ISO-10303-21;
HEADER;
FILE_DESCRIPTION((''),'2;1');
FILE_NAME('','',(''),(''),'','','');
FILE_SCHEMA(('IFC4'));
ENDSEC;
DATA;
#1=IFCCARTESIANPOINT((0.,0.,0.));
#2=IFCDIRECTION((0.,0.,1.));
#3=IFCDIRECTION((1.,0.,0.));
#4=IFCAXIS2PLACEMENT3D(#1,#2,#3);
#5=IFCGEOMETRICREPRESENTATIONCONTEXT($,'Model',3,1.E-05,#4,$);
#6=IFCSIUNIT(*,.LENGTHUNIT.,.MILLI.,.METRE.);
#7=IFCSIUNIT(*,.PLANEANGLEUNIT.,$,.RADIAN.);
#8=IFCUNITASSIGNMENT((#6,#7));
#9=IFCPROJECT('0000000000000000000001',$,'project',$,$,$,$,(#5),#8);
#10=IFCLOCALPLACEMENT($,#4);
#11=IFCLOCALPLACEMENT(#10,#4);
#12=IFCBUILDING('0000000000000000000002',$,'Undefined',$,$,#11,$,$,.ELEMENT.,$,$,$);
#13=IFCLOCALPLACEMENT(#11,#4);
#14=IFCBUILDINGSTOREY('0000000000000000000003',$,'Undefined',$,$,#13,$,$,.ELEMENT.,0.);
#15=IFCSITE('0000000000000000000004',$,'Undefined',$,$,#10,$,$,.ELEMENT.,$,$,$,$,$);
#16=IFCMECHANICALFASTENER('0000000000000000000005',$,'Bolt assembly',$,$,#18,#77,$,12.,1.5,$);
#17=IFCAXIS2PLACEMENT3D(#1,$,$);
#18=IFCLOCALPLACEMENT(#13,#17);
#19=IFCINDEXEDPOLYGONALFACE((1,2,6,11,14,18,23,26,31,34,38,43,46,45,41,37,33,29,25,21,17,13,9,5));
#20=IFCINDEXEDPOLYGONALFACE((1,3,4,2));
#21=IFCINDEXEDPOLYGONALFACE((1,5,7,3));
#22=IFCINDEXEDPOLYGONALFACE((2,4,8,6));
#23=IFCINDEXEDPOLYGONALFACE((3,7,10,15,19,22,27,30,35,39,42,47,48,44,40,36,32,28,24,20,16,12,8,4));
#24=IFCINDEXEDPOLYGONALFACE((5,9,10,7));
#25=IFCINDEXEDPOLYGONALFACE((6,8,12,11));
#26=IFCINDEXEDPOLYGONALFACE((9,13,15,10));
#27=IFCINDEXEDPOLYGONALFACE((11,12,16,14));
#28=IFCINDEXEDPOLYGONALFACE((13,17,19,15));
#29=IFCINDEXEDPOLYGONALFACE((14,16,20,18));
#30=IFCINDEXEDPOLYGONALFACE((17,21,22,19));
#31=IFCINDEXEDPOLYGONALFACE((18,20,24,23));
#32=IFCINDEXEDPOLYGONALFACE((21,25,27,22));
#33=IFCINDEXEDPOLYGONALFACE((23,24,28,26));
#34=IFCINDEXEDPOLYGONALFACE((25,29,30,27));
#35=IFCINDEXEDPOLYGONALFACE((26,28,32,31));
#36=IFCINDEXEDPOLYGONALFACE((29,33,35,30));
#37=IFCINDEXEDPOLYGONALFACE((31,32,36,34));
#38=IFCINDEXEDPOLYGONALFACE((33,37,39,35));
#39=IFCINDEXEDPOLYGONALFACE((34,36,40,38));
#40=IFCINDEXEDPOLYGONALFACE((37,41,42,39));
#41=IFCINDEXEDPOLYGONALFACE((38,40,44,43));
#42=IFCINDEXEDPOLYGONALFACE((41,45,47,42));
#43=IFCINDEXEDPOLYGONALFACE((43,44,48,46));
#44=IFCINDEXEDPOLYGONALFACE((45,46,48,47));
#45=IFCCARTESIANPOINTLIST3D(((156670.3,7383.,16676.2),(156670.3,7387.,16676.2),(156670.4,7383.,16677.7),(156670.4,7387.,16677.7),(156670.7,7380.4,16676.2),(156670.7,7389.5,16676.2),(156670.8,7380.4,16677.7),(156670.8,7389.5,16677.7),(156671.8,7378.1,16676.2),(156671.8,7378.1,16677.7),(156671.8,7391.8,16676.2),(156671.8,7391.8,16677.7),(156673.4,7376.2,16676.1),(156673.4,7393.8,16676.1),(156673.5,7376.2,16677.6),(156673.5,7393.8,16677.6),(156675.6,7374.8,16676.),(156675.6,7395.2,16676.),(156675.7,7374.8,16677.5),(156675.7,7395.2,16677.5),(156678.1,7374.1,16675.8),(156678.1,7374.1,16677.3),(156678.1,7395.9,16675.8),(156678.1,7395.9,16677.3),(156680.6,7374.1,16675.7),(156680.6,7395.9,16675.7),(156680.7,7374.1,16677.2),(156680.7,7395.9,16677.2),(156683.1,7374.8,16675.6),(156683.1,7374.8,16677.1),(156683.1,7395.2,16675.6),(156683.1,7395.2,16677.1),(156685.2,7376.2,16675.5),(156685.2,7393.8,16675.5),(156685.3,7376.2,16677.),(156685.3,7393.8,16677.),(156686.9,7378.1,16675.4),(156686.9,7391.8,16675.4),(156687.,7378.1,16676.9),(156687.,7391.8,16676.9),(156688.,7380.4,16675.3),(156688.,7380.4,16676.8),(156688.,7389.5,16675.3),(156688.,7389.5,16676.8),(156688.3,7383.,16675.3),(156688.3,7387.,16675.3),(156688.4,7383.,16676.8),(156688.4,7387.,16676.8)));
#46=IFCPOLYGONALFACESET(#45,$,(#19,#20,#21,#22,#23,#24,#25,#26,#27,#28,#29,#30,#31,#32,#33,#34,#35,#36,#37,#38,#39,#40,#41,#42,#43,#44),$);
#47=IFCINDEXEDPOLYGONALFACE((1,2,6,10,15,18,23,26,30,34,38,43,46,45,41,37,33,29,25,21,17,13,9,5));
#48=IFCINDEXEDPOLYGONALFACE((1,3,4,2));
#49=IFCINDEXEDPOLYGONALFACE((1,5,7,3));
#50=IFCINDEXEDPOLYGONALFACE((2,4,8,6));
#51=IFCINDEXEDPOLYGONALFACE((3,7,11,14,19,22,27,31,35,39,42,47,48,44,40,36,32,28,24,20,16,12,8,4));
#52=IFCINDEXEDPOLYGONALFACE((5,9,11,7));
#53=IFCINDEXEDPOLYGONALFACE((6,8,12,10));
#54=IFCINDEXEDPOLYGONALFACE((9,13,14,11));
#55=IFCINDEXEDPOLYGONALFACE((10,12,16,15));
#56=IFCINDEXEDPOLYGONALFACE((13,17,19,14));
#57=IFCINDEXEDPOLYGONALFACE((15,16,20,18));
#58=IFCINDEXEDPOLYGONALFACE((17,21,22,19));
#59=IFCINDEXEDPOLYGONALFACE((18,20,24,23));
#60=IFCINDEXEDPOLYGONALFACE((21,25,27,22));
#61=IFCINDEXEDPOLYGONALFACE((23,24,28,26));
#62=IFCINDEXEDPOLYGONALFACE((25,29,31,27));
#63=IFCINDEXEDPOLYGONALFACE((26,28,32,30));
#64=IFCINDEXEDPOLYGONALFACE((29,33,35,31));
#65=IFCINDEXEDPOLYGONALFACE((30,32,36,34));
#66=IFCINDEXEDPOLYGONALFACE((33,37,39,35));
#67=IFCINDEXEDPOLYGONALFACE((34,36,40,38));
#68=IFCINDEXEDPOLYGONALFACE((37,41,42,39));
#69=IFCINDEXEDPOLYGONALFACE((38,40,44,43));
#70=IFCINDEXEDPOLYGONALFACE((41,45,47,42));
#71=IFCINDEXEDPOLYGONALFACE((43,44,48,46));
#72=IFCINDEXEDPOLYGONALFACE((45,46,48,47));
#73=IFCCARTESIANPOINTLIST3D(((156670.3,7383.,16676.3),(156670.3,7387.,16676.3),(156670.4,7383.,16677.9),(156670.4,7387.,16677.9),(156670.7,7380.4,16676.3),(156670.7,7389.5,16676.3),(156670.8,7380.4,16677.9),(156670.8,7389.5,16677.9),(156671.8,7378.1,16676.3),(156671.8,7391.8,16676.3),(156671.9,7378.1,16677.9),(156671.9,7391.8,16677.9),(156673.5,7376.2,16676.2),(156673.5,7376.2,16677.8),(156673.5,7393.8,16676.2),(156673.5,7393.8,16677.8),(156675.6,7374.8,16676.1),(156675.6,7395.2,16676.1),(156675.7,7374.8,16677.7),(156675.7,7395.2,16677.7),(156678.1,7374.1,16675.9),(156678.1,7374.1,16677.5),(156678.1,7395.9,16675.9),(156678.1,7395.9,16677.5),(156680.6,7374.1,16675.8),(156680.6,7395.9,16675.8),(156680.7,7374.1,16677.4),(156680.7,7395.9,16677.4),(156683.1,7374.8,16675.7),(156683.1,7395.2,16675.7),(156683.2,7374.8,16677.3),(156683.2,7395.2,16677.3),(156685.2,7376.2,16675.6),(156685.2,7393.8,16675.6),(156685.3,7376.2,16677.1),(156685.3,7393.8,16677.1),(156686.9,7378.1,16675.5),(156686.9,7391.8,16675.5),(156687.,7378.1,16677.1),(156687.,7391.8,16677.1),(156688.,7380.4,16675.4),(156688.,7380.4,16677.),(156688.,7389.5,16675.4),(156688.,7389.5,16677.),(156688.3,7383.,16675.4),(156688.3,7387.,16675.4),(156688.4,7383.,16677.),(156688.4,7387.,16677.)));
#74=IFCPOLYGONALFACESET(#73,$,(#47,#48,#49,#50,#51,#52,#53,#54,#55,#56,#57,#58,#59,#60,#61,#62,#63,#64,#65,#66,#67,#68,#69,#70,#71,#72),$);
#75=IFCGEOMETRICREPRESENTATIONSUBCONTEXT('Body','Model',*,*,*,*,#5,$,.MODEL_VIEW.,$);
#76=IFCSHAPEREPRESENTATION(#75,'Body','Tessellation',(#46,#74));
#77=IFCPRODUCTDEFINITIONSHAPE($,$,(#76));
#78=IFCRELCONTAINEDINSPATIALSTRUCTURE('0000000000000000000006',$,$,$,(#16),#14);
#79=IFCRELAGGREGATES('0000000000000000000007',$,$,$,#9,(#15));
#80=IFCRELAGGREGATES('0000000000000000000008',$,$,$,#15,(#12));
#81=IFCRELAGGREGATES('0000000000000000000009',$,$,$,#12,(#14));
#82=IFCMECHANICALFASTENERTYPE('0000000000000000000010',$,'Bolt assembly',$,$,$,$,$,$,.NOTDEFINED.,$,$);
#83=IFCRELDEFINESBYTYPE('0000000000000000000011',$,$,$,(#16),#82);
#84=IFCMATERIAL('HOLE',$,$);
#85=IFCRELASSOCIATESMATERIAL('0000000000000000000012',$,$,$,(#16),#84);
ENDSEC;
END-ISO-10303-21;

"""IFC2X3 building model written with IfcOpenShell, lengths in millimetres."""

from ifc_helpers import new_model, entity, si_unit, frame, origin_with_axes, place, context, subcontext, project, spatial, source, transform, mapped, material, type_object, element, save


model = new_model("IFC2X3")

# Units and contexts
model_context = context("Model", 3, precision=1e-05, world=origin_with_axes())
body_context = subcontext(model_context, "Body", "Model", "MODEL_VIEW")
ifc_project = project(units=[si_unit("LENGTHUNIT", "METRE", prefix="MILLI"), si_unit("PLANEANGLEUNIT", "RADIAN")], contexts=[model_context])

# Site, building, storey
site_placement = place(None, origin_with_axes())
site = spatial("IfcSite", under=ifc_project, at=site_placement, Name="Undefined", CompositionType="ELEMENT")
building_placement = place(site_placement, origin_with_axes())
building = spatial("IfcBuilding", under=site, at=building_placement, Name="Undefined", CompositionType="ELEMENT")
storey_placement = place(building_placement, origin_with_axes())
storey = spatial("IfcBuildingStorey", under=building, at=storey_placement, Name="Undefined", CompositionType="ELEMENT", Elevation=0.0)

# Mechanical fastener
ifc_material_1 = material(Name="HOLE")
mechanical_fastener_type = type_object("IfcMechanicalFastenerType", Name="Bolt assembly")
shared_circle_1 = entity("IfcCircle", entity("IfcAxis2Placement2D", entity("IfcCartesianPoint", [0.0, -2.0]), entity("IfcDirection", [1.0, 0.0])), 9.0)
shared_circle_2 = entity("IfcCircle", entity("IfcAxis2Placement2D", entity("IfcCartesianPoint", [0.0, 2.0]), entity("IfcDirection", [-1.0, 0.0])), 9.0)
shared_composite_curve = entity("IfcCompositeCurve", [entity("IfcCompositeCurveSegment", "CONTINUOUS", True, entity("IfcPolyline", [entity("IfcCartesianPoint", [9.0, 2.0]), entity("IfcCartesianPoint", [9.0, -2.0])])), entity("IfcCompositeCurveSegment", "CONTINUOUS", True, entity("IfcTrimmedCurve", shared_circle_1, [entity("IfcParameterValue", 0.0)], [entity("IfcParameterValue", 3.141593)], False, "PARAMETER")), entity("IfcCompositeCurveSegment", "CONTINUOUS", True, entity("IfcPolyline", [entity("IfcCartesianPoint", [-9.0, -2.0]), entity("IfcCartesianPoint", [-9.0, 2.0])])), entity("IfcCompositeCurveSegment", "DISCONTINUOUS", True, entity("IfcTrimmedCurve", shared_circle_2, [entity("IfcParameterValue", 0.0)], [entity("IfcParameterValue", 3.141593)], False, "PARAMETER"))], False)
shared_shape_1 = source(origin_with_axes(), body_context, "Body", "SweptSolid", [
    entity("IfcExtrudedAreaSolid", entity("IfcArbitraryClosedProfileDef", "AREA", None, shared_composite_curve), entity("IfcAxis2Placement3D", entity("IfcCartesianPoint", [0.0, -0.4, 0.0]), entity("IfcDirection", [0.0, 1.0, 0.0]), entity("IfcDirection", [1.0, 0.0, 0.0])), entity("IfcDirection", [0.0, 0.0, 1.0]), 1.5),
    entity("IfcExtrudedAreaSolid", entity("IfcArbitraryClosedProfileDef", "AREA", None, shared_composite_curve), entity("IfcAxis2Placement3D", entity("IfcCartesianPoint", [0.0, -0.6, 0.0]), entity("IfcDirection", [0.0, 1.0, 0.0]), entity("IfcDirection", [1.0, 0.0, 0.0])), entity("IfcDirection", [0.0, 0.0, 1.0]), 1.6),
])
mechanical_fastener_1_placement = place(storey_placement, frame((156679.4, 7385.0, 16676.9), z_axis=(0.0, 1.0, 0.0), x_axis=(0.998627, 0.0, -0.052392)))
element("IfcMechanicalFastener", 1, at=mechanical_fastener_1_placement, inside=storey, type_object=mechanical_fastener_type, material=ifc_material_1, Name="Bolt assembly", NominalDiameter=12.0, NominalLength=1.5, context=body_context, shape_type="MappedRepresentation", body=[
    mapped(shared_shape_1, transform((0.0, 0.0, 0.0))),
])

save(model, "model.ifc")
